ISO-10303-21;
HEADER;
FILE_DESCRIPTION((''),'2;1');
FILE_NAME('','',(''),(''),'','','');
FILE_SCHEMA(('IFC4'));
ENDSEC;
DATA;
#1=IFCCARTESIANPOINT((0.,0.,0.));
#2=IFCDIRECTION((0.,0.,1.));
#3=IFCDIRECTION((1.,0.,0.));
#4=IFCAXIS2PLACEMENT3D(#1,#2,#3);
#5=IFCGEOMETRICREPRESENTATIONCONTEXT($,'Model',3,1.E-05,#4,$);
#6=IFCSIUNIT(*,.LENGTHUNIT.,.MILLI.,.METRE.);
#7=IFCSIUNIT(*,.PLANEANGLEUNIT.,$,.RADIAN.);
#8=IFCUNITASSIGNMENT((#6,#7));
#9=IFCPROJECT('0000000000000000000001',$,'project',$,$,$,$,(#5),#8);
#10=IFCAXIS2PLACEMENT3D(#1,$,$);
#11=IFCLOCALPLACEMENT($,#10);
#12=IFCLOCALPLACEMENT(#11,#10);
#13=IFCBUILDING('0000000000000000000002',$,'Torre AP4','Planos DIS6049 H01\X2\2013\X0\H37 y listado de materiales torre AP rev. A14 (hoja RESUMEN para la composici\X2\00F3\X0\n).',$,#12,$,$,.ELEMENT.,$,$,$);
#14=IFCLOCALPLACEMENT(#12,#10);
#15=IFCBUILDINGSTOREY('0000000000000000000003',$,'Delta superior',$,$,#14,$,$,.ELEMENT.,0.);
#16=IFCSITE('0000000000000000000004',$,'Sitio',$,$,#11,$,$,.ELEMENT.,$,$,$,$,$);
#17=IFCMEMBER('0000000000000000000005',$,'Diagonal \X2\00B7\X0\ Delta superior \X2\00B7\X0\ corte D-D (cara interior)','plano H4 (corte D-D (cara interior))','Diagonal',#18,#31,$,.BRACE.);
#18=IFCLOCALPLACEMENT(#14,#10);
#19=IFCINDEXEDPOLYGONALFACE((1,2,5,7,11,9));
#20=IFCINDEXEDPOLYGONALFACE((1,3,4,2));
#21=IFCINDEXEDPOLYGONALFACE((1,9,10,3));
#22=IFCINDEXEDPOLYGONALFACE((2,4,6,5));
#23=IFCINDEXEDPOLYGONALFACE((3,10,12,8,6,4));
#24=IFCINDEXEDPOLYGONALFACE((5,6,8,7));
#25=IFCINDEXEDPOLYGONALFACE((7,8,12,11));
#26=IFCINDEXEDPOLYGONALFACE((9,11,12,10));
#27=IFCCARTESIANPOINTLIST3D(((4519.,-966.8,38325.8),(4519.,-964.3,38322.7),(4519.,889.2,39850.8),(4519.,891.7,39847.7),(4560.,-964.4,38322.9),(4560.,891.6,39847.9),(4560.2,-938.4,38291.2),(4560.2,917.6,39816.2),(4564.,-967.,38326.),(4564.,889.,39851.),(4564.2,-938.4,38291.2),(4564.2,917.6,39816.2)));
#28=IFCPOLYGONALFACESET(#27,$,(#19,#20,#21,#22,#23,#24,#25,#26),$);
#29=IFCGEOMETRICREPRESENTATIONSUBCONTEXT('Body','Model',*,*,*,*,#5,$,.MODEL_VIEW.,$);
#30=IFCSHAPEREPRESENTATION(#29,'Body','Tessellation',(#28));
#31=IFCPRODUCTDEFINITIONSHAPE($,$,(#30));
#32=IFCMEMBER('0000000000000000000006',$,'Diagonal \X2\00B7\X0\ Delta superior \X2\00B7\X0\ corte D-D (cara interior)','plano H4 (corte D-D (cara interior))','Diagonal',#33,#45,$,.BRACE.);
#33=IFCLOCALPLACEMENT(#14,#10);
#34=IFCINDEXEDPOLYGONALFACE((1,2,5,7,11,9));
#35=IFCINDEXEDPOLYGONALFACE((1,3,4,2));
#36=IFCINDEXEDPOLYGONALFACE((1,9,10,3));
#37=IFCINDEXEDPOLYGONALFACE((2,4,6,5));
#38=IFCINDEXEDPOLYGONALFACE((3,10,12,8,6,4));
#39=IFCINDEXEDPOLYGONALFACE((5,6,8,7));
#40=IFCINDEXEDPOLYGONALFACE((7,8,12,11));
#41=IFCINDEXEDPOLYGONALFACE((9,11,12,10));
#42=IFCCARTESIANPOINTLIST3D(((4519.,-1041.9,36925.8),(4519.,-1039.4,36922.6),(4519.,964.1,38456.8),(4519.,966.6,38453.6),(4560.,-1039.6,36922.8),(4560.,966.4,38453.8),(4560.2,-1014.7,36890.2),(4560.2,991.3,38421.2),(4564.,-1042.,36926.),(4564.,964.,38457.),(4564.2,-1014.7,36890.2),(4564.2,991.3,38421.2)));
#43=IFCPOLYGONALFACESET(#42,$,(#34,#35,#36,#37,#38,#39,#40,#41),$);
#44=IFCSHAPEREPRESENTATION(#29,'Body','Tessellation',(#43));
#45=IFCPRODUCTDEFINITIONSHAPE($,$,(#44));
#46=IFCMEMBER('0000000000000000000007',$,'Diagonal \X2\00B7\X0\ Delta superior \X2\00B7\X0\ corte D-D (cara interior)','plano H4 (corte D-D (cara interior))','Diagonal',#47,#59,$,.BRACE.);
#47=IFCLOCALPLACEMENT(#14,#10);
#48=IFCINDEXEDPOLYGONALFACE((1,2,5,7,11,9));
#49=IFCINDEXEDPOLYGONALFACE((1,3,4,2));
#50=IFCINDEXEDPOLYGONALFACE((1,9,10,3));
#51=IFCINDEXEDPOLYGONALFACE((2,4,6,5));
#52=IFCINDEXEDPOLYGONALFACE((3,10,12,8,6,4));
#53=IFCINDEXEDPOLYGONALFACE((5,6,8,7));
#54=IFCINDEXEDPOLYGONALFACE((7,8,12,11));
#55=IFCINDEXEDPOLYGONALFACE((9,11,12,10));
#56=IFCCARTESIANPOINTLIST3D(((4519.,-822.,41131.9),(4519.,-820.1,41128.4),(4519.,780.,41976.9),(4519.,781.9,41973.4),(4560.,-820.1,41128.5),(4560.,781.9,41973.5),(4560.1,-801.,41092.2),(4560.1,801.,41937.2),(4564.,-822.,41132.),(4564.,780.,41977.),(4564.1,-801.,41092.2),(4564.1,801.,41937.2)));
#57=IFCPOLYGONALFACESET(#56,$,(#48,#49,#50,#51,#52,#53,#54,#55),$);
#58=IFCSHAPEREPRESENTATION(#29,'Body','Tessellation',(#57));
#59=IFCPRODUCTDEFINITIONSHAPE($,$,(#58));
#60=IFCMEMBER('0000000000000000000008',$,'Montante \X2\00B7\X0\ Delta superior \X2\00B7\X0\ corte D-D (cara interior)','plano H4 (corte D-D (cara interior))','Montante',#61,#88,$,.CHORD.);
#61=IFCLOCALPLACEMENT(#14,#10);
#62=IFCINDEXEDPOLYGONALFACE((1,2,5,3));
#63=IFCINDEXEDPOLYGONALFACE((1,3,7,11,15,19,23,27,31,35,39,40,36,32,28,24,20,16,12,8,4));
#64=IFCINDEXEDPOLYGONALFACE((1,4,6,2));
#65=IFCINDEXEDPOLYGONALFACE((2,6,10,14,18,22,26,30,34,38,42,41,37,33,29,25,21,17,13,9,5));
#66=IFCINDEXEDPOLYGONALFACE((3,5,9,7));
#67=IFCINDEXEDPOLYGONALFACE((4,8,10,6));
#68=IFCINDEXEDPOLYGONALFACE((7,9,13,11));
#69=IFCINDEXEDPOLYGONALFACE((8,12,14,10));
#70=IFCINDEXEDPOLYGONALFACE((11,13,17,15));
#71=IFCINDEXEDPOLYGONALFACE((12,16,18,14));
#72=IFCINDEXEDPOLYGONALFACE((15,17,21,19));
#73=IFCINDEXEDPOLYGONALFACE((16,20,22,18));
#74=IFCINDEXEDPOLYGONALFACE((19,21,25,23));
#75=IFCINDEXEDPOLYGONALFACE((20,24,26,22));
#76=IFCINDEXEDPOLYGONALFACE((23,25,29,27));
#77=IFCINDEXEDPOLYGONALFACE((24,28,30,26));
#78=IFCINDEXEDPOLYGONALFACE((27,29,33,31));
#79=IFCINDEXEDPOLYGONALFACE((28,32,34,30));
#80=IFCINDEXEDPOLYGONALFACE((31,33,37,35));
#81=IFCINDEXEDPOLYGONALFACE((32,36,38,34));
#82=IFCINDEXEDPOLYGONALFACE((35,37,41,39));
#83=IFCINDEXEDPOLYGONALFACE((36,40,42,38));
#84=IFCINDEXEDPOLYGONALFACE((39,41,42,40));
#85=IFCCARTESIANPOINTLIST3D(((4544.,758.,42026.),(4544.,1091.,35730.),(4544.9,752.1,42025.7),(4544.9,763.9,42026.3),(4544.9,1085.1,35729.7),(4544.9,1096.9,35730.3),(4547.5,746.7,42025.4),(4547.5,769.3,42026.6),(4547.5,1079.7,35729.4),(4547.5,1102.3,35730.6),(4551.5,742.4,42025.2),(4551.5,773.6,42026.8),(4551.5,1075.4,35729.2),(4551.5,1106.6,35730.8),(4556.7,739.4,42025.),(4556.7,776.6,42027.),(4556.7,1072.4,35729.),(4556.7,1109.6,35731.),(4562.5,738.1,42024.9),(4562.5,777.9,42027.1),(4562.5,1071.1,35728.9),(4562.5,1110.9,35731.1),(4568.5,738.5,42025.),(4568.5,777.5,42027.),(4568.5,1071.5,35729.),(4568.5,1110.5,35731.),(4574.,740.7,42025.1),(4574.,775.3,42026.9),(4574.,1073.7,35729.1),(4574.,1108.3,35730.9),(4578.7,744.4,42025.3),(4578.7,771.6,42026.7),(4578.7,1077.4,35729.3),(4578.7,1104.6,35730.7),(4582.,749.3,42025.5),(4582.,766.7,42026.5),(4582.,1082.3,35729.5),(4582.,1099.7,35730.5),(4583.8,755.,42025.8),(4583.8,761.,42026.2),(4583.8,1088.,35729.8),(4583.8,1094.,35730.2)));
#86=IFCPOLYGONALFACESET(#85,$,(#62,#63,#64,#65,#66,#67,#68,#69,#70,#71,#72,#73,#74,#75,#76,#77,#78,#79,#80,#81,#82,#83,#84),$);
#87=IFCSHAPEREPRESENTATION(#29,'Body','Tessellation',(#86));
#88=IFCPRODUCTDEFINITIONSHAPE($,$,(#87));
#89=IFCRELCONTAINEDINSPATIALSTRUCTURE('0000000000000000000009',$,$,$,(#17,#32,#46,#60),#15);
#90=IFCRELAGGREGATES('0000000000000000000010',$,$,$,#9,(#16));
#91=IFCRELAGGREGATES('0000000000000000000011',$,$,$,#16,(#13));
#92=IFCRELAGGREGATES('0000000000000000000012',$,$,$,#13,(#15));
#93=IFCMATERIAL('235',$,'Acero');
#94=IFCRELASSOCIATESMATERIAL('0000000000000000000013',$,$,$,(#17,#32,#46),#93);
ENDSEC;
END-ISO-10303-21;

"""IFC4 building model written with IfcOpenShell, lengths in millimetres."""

from ifc_helpers import new_model, si_unit, frame, frame_2d, origin, origin_with_axes, place, context, subcontext, project, spatial, circle, l_section, extrude, material, element, save


model = new_model("IFC4")

# Units and contexts
model_context = context("Model", 3, precision=1e-05, world=origin_with_axes())
body_context = subcontext(model_context, "Body", "Model", "MODEL_VIEW")
ifc_project = project(units=[si_unit("LENGTHUNIT", "METRE", prefix="MILLI"), si_unit("PLANEANGLEUNIT", "RADIAN")], contexts=[model_context])

# Site, building, storey
site_placement = place(None, origin())
site = spatial("IfcSite", under=ifc_project, at=site_placement, Name="Sitio", CompositionType="ELEMENT")
building_placement = place(site_placement, origin())
building = spatial("IfcBuilding", under=site, at=building_placement, Name="Torre AP4", Description="Planos DIS6049 H01–H37 y listado de materiales torre AP rev. A14 (hoja RESUMEN para la composición).", CompositionType="ELEMENT")
storey_placement = place(building_placement, origin())
storey = spatial("IfcBuildingStorey", under=building, at=storey_placement, Name="Delta superior", CompositionType="ELEMENT", Elevation=0.0)

# Members
ifc_material_1 = material(Name="235", Category="Acero")
member_1_placement = place(storey_placement, frame((4564.0, 889.0, 39851.0), z_axis=(0.0, -0.772639, -0.634846), x_axis=(-0.999985, 0.003444, -0.004191)))
element("IfcMember", 1, at=member_1_placement, inside=storey, material=ifc_material_1, Name="Diagonal · Delta superior · corte D-D (cara interior)", Description="plano H4 (corte D-D (cara interior))", ObjectType="Diagonal", PredefinedType="BRACE", context=body_context, shape_type="SweptSolid", body=[
    extrude(l_section(Depth=45.0, Width=45.0, Thickness=4.0, at=frame_2d((22.5, 22.5))), None, (0.0, 0.0, 1.0), 2402.2),
])
member_2_placement = place(storey_placement, frame((4564.0, 964.0, 38457.0), z_axis=(0.0, -0.794931, -0.6067), x_axis=(-0.999987, 0.003145, -0.004121)))
element("IfcMember", 2, at=member_2_placement, inside=storey, material=ifc_material_1, Name="Diagonal · Delta superior · corte D-D (cara interior)", Description="plano H4 (corte D-D (cara interior))", ObjectType="Diagonal", PredefinedType="BRACE", context=body_context, shape_type="SweptSolid", body=[
    extrude(l_section(Depth=45.0, Width=45.0, Thickness=4.0, at=frame_2d((22.5, 22.5))), None, (0.0, 0.0, 1.0), 2523.5),
])
member_3_placement = place(storey_placement, frame((4564.0, 780.0, 41977.0), z_axis=(0.0, -0.884499, -0.466543), x_axis=(-0.999998, 0.001002, -0.001899)))
element("IfcMember", 3, at=member_3_placement, inside=storey, material=ifc_material_1, Name="Diagonal · Delta superior · corte D-D (cara interior)", Description="plano H4 (corte D-D (cara interior))", ObjectType="Diagonal", PredefinedType="BRACE", context=body_context, shape_type="SweptSolid", body=[
    extrude(l_section(Depth=45.0, Width=45.0, Thickness=4.0, at=frame_2d((22.5, 22.5))), None, (0.0, 0.0, 1.0), 1811.2),
])
member_4_placement = place(storey_placement, frame((4564.0, 1091.0, 35730.0), z_axis=(0.0, -0.052817, 0.998604), x_axis=(-1.0, 0.0, 0.0)))
element("IfcMember", 4, at=member_4_placement, inside=storey, Name="Montante · Delta superior · corte D-D (cara interior)", Description="plano H4 (corte D-D (cara interior))", ObjectType="Montante", PredefinedType="CHORD", context=body_context, shape_type="SweptSolid", body=[
    extrude(circle(Radius=20.0), None, (0.0, 0.0, 1.0), 6304.8),
])

save(model, "model.ifc")
